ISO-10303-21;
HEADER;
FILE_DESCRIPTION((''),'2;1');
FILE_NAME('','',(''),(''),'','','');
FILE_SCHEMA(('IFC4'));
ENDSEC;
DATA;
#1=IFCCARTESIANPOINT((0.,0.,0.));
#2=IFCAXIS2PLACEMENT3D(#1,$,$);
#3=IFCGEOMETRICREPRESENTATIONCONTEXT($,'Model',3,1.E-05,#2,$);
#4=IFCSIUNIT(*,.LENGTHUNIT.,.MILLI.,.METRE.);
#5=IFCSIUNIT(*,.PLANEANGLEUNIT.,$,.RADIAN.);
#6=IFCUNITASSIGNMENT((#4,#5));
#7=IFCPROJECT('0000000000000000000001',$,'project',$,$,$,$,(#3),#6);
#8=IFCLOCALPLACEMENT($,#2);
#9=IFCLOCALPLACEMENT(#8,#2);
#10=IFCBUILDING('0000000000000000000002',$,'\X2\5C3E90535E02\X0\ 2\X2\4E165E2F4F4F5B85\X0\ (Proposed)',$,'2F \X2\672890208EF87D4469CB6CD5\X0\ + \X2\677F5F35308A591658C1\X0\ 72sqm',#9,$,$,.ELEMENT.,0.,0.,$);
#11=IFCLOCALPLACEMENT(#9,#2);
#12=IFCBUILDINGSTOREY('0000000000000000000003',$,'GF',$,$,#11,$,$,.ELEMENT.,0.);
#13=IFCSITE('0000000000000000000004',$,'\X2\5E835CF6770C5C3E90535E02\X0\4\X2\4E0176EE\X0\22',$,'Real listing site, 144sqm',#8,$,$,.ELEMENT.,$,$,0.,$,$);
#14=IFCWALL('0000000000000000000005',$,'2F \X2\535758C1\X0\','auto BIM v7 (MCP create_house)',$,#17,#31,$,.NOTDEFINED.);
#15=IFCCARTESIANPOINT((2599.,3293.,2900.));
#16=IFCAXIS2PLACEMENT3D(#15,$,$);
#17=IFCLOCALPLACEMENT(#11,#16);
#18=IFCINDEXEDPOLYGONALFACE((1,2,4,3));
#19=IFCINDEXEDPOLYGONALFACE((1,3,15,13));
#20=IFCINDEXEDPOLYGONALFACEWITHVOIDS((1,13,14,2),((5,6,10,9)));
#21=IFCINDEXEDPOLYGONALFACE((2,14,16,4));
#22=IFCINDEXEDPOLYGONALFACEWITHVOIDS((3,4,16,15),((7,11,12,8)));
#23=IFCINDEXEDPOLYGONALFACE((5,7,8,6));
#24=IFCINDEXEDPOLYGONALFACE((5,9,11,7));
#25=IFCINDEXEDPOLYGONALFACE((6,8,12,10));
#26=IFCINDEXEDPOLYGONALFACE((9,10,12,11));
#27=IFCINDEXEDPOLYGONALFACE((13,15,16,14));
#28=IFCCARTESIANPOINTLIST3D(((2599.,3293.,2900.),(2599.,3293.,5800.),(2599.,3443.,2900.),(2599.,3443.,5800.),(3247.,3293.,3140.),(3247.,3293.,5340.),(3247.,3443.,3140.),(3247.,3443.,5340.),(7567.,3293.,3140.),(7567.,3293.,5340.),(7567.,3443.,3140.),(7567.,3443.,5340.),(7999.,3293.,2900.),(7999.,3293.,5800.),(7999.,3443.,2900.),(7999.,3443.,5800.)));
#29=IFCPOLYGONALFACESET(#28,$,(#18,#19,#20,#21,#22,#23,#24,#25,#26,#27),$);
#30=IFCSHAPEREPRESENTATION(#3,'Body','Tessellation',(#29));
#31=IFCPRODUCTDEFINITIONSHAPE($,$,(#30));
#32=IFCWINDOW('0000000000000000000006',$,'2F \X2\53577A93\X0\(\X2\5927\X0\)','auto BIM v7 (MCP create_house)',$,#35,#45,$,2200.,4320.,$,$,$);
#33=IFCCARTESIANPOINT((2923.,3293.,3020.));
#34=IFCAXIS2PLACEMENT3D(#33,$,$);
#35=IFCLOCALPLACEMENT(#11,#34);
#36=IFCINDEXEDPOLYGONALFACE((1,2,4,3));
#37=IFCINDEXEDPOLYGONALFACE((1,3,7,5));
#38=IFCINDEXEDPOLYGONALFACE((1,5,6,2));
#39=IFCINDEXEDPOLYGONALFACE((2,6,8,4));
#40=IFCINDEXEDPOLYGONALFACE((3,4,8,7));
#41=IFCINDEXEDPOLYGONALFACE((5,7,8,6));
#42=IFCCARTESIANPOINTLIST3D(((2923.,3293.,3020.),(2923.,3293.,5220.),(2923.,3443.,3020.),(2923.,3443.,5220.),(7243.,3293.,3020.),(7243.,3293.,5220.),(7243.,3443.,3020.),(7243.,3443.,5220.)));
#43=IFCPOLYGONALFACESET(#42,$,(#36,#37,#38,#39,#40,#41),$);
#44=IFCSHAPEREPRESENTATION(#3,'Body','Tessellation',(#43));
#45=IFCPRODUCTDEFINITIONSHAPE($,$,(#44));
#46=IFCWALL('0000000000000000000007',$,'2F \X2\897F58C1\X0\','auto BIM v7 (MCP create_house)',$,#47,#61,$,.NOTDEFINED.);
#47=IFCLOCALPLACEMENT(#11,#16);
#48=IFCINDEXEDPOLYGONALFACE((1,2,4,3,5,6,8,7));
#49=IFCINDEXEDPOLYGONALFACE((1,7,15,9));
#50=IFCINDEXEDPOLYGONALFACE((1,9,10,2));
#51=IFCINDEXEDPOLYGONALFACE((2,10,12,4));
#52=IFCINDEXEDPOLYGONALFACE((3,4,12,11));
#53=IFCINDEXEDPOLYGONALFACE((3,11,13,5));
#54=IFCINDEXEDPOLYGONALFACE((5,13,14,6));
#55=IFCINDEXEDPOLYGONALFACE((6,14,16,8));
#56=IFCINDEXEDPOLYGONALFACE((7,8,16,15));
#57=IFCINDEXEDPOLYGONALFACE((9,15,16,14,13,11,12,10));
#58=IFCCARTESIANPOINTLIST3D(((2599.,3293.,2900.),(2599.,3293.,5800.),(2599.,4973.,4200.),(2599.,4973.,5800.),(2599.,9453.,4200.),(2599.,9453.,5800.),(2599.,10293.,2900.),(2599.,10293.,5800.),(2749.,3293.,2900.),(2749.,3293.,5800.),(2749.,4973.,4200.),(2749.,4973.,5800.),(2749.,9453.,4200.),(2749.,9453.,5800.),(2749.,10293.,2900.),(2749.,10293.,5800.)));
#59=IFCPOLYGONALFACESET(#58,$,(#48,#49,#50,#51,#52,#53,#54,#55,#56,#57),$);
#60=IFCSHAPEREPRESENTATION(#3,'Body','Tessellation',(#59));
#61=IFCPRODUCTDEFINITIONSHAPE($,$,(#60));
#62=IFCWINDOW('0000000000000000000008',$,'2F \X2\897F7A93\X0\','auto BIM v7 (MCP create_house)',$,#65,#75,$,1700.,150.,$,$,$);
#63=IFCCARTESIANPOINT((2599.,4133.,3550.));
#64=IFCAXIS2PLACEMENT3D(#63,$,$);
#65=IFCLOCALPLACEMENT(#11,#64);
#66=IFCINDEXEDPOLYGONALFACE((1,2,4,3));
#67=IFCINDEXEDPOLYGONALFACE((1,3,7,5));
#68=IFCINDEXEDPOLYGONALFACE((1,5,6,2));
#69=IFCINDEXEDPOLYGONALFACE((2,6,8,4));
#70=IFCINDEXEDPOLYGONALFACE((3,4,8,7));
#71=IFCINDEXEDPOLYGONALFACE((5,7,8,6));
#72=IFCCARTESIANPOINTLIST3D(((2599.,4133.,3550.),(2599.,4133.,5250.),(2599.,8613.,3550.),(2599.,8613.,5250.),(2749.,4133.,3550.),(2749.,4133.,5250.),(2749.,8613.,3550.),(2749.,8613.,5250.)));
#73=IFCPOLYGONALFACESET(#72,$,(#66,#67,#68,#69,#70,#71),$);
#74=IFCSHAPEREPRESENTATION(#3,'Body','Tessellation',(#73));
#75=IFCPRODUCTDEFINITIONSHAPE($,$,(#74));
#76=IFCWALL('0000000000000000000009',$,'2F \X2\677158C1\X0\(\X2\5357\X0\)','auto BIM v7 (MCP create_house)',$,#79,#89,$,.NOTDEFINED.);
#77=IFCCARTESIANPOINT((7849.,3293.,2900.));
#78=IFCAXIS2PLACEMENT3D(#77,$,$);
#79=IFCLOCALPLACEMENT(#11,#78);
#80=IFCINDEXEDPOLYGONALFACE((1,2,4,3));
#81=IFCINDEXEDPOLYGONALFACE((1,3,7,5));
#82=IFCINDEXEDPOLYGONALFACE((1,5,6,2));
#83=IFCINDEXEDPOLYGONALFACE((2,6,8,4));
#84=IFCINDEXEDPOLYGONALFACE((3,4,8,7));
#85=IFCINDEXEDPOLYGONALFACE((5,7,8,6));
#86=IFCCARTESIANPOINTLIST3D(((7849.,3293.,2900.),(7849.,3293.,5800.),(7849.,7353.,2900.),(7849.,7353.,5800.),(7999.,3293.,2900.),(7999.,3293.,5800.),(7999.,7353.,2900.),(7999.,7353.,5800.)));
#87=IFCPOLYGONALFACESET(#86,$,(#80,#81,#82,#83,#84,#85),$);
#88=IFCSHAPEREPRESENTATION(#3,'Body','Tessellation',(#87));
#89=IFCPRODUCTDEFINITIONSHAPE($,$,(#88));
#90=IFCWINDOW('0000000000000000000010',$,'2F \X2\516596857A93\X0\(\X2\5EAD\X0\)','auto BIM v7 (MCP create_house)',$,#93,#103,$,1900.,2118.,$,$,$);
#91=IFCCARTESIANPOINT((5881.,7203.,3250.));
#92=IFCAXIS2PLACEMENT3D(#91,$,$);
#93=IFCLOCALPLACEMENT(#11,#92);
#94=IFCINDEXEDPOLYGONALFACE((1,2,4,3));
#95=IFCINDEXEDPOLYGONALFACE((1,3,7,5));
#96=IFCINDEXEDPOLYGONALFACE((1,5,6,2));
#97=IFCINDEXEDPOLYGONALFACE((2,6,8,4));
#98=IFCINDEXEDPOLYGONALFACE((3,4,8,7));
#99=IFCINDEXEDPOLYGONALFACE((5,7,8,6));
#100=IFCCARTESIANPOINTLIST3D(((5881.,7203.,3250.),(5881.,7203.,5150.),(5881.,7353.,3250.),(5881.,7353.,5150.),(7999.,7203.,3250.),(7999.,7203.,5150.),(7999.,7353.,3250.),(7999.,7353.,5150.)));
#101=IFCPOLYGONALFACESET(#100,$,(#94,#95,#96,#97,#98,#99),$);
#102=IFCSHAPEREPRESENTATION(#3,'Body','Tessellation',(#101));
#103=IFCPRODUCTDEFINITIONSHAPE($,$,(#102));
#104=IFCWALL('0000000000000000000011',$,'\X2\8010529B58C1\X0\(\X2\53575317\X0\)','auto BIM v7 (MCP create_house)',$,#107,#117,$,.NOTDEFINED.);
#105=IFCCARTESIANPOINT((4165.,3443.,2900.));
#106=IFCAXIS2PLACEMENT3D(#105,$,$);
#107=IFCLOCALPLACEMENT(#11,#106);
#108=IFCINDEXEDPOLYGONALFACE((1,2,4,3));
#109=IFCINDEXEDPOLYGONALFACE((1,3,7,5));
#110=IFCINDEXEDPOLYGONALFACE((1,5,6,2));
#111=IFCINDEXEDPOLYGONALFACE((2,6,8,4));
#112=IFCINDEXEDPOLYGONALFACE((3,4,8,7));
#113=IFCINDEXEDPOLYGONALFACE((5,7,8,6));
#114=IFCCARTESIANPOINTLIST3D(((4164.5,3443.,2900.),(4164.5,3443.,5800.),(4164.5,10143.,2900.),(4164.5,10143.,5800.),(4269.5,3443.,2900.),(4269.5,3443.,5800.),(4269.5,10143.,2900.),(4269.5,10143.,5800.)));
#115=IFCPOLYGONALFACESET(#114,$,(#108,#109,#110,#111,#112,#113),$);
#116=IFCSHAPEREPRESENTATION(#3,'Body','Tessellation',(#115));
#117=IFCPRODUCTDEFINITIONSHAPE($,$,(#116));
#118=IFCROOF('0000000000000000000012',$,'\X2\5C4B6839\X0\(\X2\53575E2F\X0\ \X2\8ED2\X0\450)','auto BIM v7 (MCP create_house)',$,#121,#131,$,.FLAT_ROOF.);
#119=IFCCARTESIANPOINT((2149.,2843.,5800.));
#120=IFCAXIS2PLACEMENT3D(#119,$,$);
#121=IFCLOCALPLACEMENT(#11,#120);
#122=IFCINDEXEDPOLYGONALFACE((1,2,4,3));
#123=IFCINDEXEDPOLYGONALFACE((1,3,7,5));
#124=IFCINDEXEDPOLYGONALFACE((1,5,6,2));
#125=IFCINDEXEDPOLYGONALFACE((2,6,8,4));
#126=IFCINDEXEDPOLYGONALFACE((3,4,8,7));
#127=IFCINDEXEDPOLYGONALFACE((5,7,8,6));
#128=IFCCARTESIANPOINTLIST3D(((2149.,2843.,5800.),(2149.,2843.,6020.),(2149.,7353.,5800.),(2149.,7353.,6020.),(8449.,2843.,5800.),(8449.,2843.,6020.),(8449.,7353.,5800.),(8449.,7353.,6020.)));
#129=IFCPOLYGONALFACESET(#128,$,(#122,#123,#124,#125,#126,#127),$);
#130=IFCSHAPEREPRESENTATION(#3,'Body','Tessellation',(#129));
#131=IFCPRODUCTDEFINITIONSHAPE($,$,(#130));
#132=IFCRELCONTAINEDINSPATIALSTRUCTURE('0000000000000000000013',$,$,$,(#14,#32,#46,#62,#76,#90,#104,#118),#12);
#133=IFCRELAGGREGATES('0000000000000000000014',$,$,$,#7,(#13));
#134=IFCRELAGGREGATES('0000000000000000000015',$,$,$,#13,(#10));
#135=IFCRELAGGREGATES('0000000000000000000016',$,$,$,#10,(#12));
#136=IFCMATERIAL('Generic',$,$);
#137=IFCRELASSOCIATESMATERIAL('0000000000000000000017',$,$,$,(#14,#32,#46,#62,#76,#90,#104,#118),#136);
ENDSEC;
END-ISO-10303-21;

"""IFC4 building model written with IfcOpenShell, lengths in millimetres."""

from ifc_helpers import new_model, si_unit, frame, frame_2d, origin, place, context, project, spatial, rectangle, extrude, material, element, fill, save


model = new_model("IFC4")

# Units and contexts
model_context = context("Model", 3, precision=1e-05, world=origin())
ifc_project = project(units=[si_unit("LENGTHUNIT", "METRE", prefix="MILLI"), si_unit("PLANEANGLEUNIT", "RADIAN")], contexts=[model_context])

# Site, building, storey
site_placement = place(None, origin())
site = spatial("IfcSite", under=ifc_project, at=site_placement, Name="広島県尾道市4丁目22", ObjectType="Real listing site, 144sqm", CompositionType="ELEMENT", RefElevation=0.0)
building_placement = place(site_placement, origin())
building = spatial("IfcBuilding", under=site, at=building_placement, Name="尾道市 2世帯住宅 (Proposed)", ObjectType="2F 木造軸組構法 + 板張り外壁 72sqm", CompositionType="ELEMENT", ElevationOfRefHeight=0.0, ElevationOfTerrain=0.0)
storey_placement = place(building_placement, origin())
storey = spatial("IfcBuildingStorey", under=building, at=storey_placement, Name="GF", CompositionType="ELEMENT", Elevation=0.0)

# Shared definitions
ifc_material = material(Name="Generic")

# Walls, openings, windows
wall_1_placement = place(storey_placement, frame((2599.0, 3293.0, 2900.0)))
wall_1 = element("IfcWall", 1, at=wall_1_placement, inside=storey, material=ifc_material, Name="2F 南壁", Description="auto BIM v7 (MCP create_house)", PredefinedType="NOTDEFINED", context=model_context, shape_type="SweptSolid", body=[
    extrude(rectangle(XDim=5400.0, YDim=150.0, at=frame_2d((2700.0, 75.0))), frame((2599.0, 3293.0, 2900.0)), (0.0, 0.0, 1.0), 2900.0),
])
opening_1_placement = place(storey_placement, frame((2923.0, 3293.0, 3020.0)))
opening_1 = element("IfcOpeningElement", 2, at=opening_1_placement, cuts=wall_1, PredefinedType="NOTDEFINED", context=model_context, shape_type="SweptSolid", body=[
    extrude(rectangle(XDim=4320.0, YDim=150.0, at=frame_2d((2160.0, 75.0))), frame((2923.0, 3293.0, 3020.0)), (0.0, 0.0, 1.0), 2200.0),
])
window_1_placement = place(storey_placement, frame((2923.0, 3293.0, 3020.0)))
window_1 = element("IfcWindow", 3, at=window_1_placement, inside=storey, material=ifc_material, Name="2F 南窓(大)", Description="auto BIM v7 (MCP create_house)", OverallHeight=2200.0, OverallWidth=4320.0, context=model_context, shape_type="SweptSolid", body=[
    extrude(rectangle(XDim=4320.0, YDim=150.0, at=frame_2d((2160.0, 75.0))), frame((2923.0, 3293.0, 3020.0)), (0.0, 0.0, 1.0), 2200.0),
])
fill(opening_1, window_1)
wall_2_placement = place(storey_placement, frame((2599.0, 3293.0, 2900.0)))
wall_2 = element("IfcWall", 4, at=wall_2_placement, inside=storey, material=ifc_material, Name="2F 西壁", Description="auto BIM v7 (MCP create_house)", PredefinedType="NOTDEFINED", context=model_context, shape_type="SweptSolid", body=[
    extrude(rectangle(XDim=150.0, YDim=7000.0, at=frame_2d((75.0, 3500.0))), frame((2599.0, 3293.0, 2900.0)), (0.0, 0.0, 1.0), 2900.0),
])
opening_2_placement = place(storey_placement, frame((2599.0, 4133.0, 3550.0)))
opening_2 = element("IfcOpeningElement", 5, at=opening_2_placement, cuts=wall_2, PredefinedType="NOTDEFINED", context=model_context, shape_type="SweptSolid", body=[
    extrude(rectangle(XDim=150.0, YDim=4480.0, at=frame_2d((75.0, 2240.0))), frame((2599.0, 4133.0, 3550.0)), (0.0, 0.0, 1.0), 1700.0),
])
window_2_placement = place(storey_placement, frame((2599.0, 4133.0, 3550.0)))
window_2 = element("IfcWindow", 6, at=window_2_placement, inside=storey, material=ifc_material, Name="2F 西窓", Description="auto BIM v7 (MCP create_house)", OverallHeight=1700.0, OverallWidth=150.0, context=model_context, shape_type="SweptSolid", body=[
    extrude(rectangle(XDim=150.0, YDim=4480.0, at=frame_2d((75.0, 2240.0))), frame((2599.0, 4133.0, 3550.0)), (0.0, 0.0, 1.0), 1700.0),
])
fill(opening_2, window_2)
wall_3_placement = place(storey_placement, frame((7849.0, 3293.0, 2900.0)))
wall_3 = element("IfcWall", 7, at=wall_3_placement, inside=storey, material=ifc_material, Name="2F 東壁(南)", Description="auto BIM v7 (MCP create_house)", PredefinedType="NOTDEFINED", context=model_context, shape_type="SweptSolid", body=[
    extrude(rectangle(XDim=150.0, YDim=4060.0, at=frame_2d((75.0, 2030.0))), frame((7849.0, 3293.0, 2900.0)), (0.0, 0.0, 1.0), 2900.0),
])
opening_3_placement = place(storey_placement, frame((5881.0, 7203.0, 3250.0)))
opening_3 = element("IfcOpeningElement", 8, at=opening_3_placement, cuts=wall_3, PredefinedType="NOTDEFINED", context=model_context, shape_type="SweptSolid", body=[
    extrude(rectangle(XDim=2118.0, YDim=150.0, at=frame_2d((1059.0, 75.0))), frame((5881.0, 7203.0, 3250.0)), (0.0, 0.0, 1.0), 1900.0),
])
window_3_placement = place(storey_placement, frame((5881.0, 7203.0, 3250.0)))
window_3 = element("IfcWindow", 9, at=window_3_placement, inside=storey, material=ifc_material, Name="2F 入隅窓(庭)", Description="auto BIM v7 (MCP create_house)", OverallHeight=1900.0, OverallWidth=2118.0, context=model_context, shape_type="SweptSolid", body=[
    extrude(rectangle(XDim=2118.0, YDim=150.0, at=frame_2d((1059.0, 75.0))), frame((5881.0, 7203.0, 3250.0)), (0.0, 0.0, 1.0), 1900.0),
])
fill(opening_3, window_3)

# Wall
wall_4_placement = place(storey_placement, frame((4165.0, 3443.0, 2900.0)))
element("IfcWall", 10, at=wall_4_placement, inside=storey, material=ifc_material, Name="耐力壁(南北)", Description="auto BIM v7 (MCP create_house)", PredefinedType="NOTDEFINED", context=model_context, shape_type="SweptSolid", body=[
    extrude(rectangle(XDim=105.0, YDim=6700.0, at=frame_2d((52.0, 3350.0))), frame((4165.0, 3443.0, 2900.0)), (0.0, 0.0, 1.0), 2900.0),
])

# Roof
for number, where, name in (
    (11, (2149.0, 2843.0, 5800.0), "屋根(南帯 軒450)"),
):
    element("IfcRoof", number, at=place(storey_placement, frame(where)), inside=storey, material=ifc_material, Name=name, Description="auto BIM v7 (MCP create_house)", PredefinedType="FLAT_ROOF", context=model_context, shape_type="SweptSolid", body=[
        extrude(rectangle(XDim=6300.0, YDim=4510.0, at=frame_2d((3150.0, 2255.0))), frame((2149.0, 2843.0, 5800.0)), (0.0, 0.0, 1.0), 220.0),
    ])

save(model, "model.ifc")
